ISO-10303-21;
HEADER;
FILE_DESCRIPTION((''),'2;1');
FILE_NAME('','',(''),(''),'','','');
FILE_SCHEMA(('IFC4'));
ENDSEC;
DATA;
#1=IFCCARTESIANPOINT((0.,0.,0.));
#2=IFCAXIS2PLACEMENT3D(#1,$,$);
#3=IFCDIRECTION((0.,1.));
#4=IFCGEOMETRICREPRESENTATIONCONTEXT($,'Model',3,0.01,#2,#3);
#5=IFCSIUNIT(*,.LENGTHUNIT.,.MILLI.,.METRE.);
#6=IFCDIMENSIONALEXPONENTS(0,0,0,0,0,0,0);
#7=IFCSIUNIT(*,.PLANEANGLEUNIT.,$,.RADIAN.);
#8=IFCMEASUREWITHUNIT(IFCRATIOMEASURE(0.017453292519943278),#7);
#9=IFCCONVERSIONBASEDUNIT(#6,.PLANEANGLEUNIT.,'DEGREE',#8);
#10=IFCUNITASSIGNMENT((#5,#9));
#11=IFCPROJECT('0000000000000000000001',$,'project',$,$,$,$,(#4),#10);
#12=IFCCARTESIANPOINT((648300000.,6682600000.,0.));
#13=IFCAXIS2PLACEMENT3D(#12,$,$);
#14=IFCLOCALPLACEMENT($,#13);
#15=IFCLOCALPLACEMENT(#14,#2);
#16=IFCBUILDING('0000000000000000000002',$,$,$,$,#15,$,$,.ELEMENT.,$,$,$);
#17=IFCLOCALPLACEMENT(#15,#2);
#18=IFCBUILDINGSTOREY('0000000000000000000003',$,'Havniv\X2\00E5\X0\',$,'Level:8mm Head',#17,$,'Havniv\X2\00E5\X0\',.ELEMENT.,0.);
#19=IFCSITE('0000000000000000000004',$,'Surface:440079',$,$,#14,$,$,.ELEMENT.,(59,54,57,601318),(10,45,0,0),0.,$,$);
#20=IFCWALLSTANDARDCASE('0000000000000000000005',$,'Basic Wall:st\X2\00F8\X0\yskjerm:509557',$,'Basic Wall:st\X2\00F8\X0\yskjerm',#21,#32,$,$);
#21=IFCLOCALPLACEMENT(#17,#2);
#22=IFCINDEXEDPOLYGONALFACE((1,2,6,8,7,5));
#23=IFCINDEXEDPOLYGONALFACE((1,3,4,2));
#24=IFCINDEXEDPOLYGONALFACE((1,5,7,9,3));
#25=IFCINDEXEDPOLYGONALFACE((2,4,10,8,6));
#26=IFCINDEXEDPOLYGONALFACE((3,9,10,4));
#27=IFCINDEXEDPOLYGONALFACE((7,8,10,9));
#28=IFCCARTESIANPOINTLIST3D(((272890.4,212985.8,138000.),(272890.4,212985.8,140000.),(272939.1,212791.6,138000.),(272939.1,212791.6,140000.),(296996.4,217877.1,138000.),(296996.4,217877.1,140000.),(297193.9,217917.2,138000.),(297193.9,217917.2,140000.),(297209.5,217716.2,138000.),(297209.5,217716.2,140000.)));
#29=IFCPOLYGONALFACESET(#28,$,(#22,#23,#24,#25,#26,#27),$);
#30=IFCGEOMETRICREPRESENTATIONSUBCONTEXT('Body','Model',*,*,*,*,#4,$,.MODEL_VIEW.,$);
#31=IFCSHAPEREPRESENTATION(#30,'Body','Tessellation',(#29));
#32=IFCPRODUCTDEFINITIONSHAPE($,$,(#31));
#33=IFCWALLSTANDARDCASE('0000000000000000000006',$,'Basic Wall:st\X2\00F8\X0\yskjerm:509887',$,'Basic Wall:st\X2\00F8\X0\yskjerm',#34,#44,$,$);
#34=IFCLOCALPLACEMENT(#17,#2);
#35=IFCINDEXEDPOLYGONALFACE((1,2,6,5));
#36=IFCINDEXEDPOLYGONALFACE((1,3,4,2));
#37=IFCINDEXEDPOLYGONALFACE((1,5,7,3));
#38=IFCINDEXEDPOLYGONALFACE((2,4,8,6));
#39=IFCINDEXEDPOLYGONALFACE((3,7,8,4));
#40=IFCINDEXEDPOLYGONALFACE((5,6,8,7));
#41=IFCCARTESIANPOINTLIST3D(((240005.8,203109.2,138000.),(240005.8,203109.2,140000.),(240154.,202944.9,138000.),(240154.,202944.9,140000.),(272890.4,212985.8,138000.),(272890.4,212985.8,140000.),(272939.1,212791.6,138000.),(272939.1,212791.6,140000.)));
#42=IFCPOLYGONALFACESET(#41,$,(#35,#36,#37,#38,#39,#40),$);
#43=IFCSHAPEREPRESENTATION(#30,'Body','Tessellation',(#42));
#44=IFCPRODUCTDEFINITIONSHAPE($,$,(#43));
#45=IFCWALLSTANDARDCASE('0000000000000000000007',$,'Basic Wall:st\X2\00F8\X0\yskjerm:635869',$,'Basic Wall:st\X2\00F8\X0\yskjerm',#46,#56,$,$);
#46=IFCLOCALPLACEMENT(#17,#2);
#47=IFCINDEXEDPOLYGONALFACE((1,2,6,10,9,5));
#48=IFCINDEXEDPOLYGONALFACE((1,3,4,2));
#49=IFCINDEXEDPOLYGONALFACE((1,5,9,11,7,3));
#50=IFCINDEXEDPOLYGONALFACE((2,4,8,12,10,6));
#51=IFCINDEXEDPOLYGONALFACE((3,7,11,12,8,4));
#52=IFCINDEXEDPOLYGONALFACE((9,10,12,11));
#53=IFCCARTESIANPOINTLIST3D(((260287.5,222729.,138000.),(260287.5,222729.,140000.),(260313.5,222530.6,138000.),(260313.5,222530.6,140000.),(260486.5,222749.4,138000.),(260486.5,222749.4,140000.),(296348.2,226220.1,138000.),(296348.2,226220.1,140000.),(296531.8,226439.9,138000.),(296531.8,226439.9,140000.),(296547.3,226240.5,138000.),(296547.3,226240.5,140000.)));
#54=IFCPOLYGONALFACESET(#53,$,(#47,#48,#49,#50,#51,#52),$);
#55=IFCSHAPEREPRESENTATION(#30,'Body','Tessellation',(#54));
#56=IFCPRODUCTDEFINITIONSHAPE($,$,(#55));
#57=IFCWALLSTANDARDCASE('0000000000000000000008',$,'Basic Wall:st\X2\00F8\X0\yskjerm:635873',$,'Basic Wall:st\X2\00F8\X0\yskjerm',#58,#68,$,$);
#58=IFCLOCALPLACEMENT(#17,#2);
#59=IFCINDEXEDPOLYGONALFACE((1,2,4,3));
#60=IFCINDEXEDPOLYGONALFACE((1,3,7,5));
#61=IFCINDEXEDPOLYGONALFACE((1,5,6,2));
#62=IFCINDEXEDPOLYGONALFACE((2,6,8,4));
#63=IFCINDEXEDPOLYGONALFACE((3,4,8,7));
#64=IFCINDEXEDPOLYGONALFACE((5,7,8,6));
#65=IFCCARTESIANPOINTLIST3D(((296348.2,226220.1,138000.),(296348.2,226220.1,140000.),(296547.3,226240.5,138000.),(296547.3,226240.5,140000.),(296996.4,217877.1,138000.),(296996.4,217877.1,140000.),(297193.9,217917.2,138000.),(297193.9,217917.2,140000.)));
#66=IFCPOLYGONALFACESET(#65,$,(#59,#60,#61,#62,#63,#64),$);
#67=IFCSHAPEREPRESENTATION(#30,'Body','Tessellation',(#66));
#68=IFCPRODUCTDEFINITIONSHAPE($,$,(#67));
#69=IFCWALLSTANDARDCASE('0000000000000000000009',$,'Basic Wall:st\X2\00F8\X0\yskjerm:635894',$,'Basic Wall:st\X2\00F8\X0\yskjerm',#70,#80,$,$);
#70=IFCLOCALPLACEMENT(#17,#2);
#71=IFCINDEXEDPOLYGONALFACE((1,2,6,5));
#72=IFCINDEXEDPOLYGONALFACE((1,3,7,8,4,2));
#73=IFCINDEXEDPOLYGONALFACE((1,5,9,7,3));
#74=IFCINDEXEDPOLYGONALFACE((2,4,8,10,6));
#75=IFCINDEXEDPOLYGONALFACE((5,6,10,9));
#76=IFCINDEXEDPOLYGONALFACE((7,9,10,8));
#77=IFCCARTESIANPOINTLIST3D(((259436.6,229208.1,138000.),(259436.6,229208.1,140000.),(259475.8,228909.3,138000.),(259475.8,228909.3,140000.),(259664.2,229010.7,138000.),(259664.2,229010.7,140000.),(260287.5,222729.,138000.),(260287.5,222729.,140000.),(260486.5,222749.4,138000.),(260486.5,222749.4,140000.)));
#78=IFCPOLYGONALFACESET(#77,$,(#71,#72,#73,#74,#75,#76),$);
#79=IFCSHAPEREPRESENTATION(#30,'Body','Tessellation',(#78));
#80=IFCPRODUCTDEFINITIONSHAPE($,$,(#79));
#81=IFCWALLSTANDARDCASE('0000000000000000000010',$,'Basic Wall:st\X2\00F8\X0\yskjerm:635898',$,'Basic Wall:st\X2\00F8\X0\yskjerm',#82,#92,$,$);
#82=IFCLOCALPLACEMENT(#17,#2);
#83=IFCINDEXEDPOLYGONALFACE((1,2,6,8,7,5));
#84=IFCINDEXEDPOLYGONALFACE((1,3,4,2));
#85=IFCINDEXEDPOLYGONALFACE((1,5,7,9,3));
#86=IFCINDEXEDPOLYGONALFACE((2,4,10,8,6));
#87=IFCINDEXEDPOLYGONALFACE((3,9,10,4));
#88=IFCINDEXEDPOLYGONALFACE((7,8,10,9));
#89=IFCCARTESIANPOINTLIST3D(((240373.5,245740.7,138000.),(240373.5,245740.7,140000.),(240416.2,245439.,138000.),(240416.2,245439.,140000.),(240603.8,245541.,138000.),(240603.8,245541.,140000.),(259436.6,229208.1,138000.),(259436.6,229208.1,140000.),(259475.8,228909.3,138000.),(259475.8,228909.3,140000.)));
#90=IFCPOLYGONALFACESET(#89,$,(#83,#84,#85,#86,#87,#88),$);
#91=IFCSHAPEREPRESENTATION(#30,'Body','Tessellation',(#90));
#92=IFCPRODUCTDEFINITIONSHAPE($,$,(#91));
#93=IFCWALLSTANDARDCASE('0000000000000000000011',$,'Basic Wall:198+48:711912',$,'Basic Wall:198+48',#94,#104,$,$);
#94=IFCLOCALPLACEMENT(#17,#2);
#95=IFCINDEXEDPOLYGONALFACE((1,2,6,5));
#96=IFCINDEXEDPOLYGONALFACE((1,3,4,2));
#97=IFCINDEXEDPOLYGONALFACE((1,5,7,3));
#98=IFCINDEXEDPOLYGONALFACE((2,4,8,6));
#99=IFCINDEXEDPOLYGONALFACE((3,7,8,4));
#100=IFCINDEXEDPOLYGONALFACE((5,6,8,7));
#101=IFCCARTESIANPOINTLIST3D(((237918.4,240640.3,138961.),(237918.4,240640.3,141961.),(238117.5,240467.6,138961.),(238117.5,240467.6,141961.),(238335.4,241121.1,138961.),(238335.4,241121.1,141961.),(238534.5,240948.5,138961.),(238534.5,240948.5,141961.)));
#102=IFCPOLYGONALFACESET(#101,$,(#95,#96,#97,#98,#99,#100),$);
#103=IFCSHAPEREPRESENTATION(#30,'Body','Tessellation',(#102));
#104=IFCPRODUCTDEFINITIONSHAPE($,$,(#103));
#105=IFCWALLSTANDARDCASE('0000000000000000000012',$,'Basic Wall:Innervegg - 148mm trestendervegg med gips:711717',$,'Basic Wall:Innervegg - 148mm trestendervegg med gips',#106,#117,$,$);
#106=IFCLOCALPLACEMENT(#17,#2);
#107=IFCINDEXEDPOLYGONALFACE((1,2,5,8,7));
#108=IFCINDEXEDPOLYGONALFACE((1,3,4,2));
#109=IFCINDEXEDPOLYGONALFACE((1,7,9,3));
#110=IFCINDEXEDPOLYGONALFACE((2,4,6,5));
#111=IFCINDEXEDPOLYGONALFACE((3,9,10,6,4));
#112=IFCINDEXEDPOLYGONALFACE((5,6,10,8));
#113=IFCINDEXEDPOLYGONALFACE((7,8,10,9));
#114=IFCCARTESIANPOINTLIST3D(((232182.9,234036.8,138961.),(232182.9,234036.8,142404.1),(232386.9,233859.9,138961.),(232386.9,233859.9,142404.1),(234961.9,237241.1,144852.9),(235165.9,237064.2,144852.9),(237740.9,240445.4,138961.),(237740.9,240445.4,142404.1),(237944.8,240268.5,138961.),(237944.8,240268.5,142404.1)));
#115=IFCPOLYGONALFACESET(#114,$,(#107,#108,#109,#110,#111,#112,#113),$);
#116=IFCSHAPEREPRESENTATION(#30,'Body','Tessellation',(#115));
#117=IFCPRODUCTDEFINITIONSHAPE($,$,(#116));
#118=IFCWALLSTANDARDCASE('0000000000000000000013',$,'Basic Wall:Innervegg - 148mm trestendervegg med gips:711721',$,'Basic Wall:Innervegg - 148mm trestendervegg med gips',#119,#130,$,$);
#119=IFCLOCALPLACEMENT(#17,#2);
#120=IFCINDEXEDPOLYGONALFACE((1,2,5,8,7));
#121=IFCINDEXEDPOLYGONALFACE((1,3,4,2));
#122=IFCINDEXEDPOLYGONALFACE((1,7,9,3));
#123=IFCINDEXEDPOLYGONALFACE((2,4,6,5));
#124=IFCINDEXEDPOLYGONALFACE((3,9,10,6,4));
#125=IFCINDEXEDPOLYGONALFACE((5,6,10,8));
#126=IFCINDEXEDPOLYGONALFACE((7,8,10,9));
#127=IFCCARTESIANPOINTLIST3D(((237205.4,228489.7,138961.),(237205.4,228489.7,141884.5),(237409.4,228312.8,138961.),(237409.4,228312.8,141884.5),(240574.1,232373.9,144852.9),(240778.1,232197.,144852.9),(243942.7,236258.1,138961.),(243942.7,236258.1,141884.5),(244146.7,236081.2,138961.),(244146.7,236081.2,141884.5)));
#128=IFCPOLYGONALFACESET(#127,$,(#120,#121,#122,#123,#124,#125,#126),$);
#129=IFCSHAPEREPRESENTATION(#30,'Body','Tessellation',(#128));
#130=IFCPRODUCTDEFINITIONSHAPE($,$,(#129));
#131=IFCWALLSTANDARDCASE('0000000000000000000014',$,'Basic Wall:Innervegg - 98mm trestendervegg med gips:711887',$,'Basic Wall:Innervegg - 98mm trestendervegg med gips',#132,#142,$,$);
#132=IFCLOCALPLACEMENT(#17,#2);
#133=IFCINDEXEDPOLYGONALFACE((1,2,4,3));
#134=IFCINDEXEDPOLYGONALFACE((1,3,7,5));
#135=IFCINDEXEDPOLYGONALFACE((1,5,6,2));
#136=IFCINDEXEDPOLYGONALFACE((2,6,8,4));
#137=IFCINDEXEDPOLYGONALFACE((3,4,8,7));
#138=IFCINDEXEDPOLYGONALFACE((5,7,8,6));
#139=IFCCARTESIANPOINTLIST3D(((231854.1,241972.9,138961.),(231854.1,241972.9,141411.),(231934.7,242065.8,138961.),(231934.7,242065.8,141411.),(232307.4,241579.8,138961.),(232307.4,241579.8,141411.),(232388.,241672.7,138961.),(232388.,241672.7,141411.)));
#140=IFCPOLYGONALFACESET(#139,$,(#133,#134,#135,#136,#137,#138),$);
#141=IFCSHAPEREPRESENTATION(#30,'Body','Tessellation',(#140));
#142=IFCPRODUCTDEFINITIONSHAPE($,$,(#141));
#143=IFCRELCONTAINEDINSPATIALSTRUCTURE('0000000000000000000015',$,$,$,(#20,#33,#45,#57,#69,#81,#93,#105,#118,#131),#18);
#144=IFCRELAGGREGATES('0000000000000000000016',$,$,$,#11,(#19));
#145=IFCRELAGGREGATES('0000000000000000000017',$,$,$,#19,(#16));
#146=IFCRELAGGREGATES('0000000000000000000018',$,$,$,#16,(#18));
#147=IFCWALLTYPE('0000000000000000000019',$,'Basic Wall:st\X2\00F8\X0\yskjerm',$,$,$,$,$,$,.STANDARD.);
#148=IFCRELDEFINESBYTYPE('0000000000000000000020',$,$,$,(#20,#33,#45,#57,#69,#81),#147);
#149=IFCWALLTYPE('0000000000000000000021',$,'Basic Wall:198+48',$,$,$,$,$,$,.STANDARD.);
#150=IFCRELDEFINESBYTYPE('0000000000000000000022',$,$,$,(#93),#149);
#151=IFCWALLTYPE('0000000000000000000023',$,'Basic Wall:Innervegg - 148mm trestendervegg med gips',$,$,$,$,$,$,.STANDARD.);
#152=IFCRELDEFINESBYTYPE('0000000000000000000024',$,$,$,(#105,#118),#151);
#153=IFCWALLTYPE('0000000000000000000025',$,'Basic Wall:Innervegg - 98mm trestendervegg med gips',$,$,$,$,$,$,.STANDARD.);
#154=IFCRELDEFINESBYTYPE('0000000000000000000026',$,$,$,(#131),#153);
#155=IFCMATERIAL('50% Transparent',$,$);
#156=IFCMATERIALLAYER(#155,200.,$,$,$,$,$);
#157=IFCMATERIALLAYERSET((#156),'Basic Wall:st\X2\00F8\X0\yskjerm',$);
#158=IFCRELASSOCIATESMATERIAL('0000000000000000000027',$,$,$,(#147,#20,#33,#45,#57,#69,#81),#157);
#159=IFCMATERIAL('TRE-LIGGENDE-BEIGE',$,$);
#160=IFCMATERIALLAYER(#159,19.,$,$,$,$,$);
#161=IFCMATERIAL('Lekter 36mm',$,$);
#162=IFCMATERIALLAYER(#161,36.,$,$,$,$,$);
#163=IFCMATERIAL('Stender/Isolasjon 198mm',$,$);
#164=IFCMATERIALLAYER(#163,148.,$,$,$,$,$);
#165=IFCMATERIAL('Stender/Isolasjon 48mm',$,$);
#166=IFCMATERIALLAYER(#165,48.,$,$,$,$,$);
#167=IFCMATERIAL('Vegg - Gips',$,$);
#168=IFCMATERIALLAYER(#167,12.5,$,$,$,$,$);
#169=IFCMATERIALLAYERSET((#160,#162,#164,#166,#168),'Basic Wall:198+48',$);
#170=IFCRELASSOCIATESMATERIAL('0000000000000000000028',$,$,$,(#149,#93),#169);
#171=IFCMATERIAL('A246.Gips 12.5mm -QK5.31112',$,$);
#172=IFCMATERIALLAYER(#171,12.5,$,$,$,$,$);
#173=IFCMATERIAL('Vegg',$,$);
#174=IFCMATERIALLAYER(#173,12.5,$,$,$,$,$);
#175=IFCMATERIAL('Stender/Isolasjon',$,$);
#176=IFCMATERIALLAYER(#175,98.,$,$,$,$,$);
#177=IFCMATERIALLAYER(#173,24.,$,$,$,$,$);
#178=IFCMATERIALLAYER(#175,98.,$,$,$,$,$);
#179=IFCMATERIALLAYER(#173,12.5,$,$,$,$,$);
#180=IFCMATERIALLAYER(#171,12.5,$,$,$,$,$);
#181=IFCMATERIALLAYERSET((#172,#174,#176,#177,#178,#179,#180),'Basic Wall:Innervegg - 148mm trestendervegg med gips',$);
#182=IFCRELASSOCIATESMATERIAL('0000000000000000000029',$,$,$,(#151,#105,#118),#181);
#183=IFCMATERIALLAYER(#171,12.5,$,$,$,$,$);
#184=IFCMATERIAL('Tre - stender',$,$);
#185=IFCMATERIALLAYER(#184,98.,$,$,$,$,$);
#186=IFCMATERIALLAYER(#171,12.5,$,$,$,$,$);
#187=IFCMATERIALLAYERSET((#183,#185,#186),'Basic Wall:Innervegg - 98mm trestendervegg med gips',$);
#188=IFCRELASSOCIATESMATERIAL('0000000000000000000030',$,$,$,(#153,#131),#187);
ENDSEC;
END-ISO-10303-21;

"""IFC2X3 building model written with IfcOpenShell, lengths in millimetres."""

from ifc_helpers import new_model, entity, si_unit, converted_unit, direction, frame, frame_2d, origin, place, context, subcontext, project, spatial, polyline, rectangle, outline, extrude, clip, bounded_halfspace, material, layer, layer_set, layer_usage, type_object, element, save


model = new_model("IFC2X3")

# Units and contexts
model_context = context("Model", 3, precision=0.01, world=origin(), true_north=direction((0.0, 1.0)))
body_context = subcontext(model_context, "Body", "Model", "MODEL_VIEW")
ifc_project = project(units=[si_unit("LENGTHUNIT", "METRE", prefix="MILLI"), converted_unit("PLANEANGLEUNIT", "DEGREE", entity("IfcRatioMeasure", 0.017453292519943278), si_unit("PLANEANGLEUNIT", "RADIAN"), dimensions=[0, 0, 0, 0, 0, 0, 0])], contexts=[model_context])

# Site, building, storey
site_placement = place(None, frame((648300000.0, 6682600000.0, 0.0)))
site = spatial("IfcSite", under=ifc_project, at=site_placement, Name="Surface:440079", CompositionType="ELEMENT", RefLatitude=(59, 54, 57, 601318), RefLongitude=(10, 45, 0, 0), RefElevation=0.0)
building_placement = place(site_placement, origin())
building = spatial("IfcBuilding", under=site, at=building_placement, CompositionType="ELEMENT")
storey_placement = place(building_placement, origin())
storey = spatial("IfcBuildingStorey", under=building, at=storey_placement, Name="Havnivå", ObjectType="Level:8mm Head", LongName="Havnivå", CompositionType="ELEMENT", Elevation=0.0)

# Walls
ifc_material_1 = material(Name="50% Transparent")
ifc_layer_1 = layer(ifc_material_1, 200.0)
ifc_layer_set_1 = layer_set([ifc_layer_1], Name="Basic Wall:støyskjerm")
ifc_layer_usage_1 = layer_usage(ifc_layer_set_1, "AXIS2", "NEGATIVE", 100.0)
wall_type_1 = type_object("IfcWallType", Name="Basic Wall:støyskjerm", PredefinedType="STANDARD", material=ifc_layer_set_1)
wall_1_placement = place(storey_placement, frame((297213.8, 217819.1, 138000.0), z_axis=(0.0, 0.0, 1.0), x_axis=(-0.980029, -0.198854, 0.0)))
element("IfcWallStandardCase", 1, at=wall_1_placement, inside=storey, type_object=wall_type_1, material=ifc_layer_usage_1, Name="Basic Wall:støyskjerm:509557", ObjectType="Basic Wall:støyskjerm", context=body_context, shape_type="SweptSolid", body=[
    extrude(outline(polyline([(24798.8, -100.0), (24789.6, 100.0), (24.7, 100.0), (0.0, -100.0), (201.5, -100.0), (24798.8, -100.0)])), origin(), (0.0, 0.0, 1.0), 2000.0),
])
ifc_layer_usage_2 = layer_usage(ifc_layer_set_1, "AXIS2", "NEGATIVE", 100.0)
wall_2_placement = place(storey_placement, frame((272919.1, 212890.0, 138000.0), z_axis=(0.0, 0.0, 1.0), x_axis=(-0.957736, -0.287648, 0.0)))
element("IfcWallStandardCase", 2, at=wall_2_placement, inside=storey, type_object=wall_type_1, material=ifc_layer_usage_2, Name="Basic Wall:støyskjerm:509887", ObjectType="Basic Wall:støyskjerm", context=body_context, shape_type="SweptSolid", body=[
    extrude(outline(polyline([(34335.7, -100.0), (34241.0, 100.0), (9.2, 100.0), (0.0, -100.0), (34335.7, -100.0)])), origin(), (0.0, 0.0, 1.0), 2000.0),
])
ifc_layer_usage_3 = layer_usage(ifc_layer_set_1, "AXIS2", "NEGATIVE", 100.0)
wall_3_placement = place(storey_placement, frame((260297.6, 222629.5, 138000.0), z_axis=(0.0, 0.0, 1.0), x_axis=(0.994799, 0.101854, 0.0)))
element("IfcWallStandardCase", 3, at=wall_3_placement, inside=storey, type_object=wall_type_1, material=ifc_layer_usage_3, Name="Basic Wall:støyskjerm:635869", ObjectType="Basic Wall:støyskjerm", context=body_context, shape_type="SweptSolid", body=[
    extrude(outline(polyline([(36428.9, -100.0), (36433.8, 100.0), (200.1, 100.0), (0.0, 100.0), (5.7, -100.0), (36228.8, -100.0), (36428.9, -100.0)])), origin(), (0.0, 0.0, 1.0), 2000.0),
])
ifc_layer_usage_4 = layer_usage(ifc_layer_set_1, "AXIS2", "NEGATIVE", 100.0)
wall_4_placement = place(storey_placement, frame((297096.1, 217884.8, 138000.0), z_axis=(0.0, 0.0, 1.0), x_axis=(-0.077456, 0.996996, 0.0)))
element("IfcWallStandardCase", 4, at=wall_4_placement, inside=storey, type_object=wall_type_1, material=ifc_layer_usage_4, Name="Basic Wall:støyskjerm:635873", ObjectType="Basic Wall:støyskjerm", context=body_context, shape_type="SweptSolid", body=[
    extrude(outline(polyline([(8373.0, -100.0), (8368.1, 100.0), (0.0, 100.0), (24.7, -100.0), (8373.0, -100.0)])), origin(), (0.0, 0.0, 1.0), 2000.0),
])
ifc_layer_usage_5 = layer_usage(ifc_layer_set_1, "AXIS2", "NEGATIVE", 100.0)
wall_5_placement = place(storey_placement, frame((259535.7, 229221.1, 138000.0), z_axis=(0.0, 0.0, 1.0), x_axis=(0.130211, -0.991486, 0.0)))
element("IfcWallStandardCase", 5, at=wall_5_placement, inside=storey, type_object=wall_type_1, material=ifc_layer_usage_5, Name="Basic Wall:støyskjerm:635894", ObjectType="Basic Wall:støyskjerm", context=body_context, shape_type="SweptSolid", body=[
    extrude(outline(polyline([(6534.7, -100.0), (6540.4, 100.0), (225.4, 100.0), (0.0, -100.0), (301.3, -100.0), (6534.7, -100.0)])), origin(), (0.0, 0.0, 1.0), 2000.0),
])
ifc_layer_usage_6 = layer_usage(ifc_layer_set_1, "AXIS2", "NEGATIVE", 100.0)
wall_6_placement = place(storey_placement, frame((259541.3, 228984.9, 138000.0), z_axis=(0.0, 0.0, 1.0), x_axis=(-0.755467, 0.655187, 0.0)))
element("IfcWallStandardCase", 6, at=wall_6_placement, inside=storey, type_object=wall_type_1, material=ifc_layer_usage_6, Name="Basic Wall:støyskjerm:635898", ObjectType="Basic Wall:støyskjerm", context=body_context, shape_type="SweptSolid", body=[
    extrude(outline(polyline([(25458.8, -100.0), (25228.9, 100.0), (0.0, 100.0), (225.4, -100.0), (25154.1, -100.0), (25458.8, -100.0)])), origin(), (0.0, 0.0, 1.0), 2000.0),
])
ifc_material_2 = material(Name="TRE-LIGGENDE-BEIGE")
ifc_layer_2 = layer(ifc_material_2, 19.0)
ifc_material_3 = material(Name="Lekter 36mm")
ifc_layer_3 = layer(ifc_material_3, 36.0)
ifc_material_4 = material(Name="Stender/Isolasjon 198mm")
ifc_layer_4 = layer(ifc_material_4, 148.0)
ifc_material_5 = material(Name="Stender/Isolasjon 48mm")
ifc_layer_5 = layer(ifc_material_5, 48.0)
ifc_material_6 = material(Name="Vegg - Gips")
ifc_layer_6 = layer(ifc_material_6, 12.5)
ifc_layer_set_2 = layer_set([ifc_layer_2, ifc_layer_3, ifc_layer_4, ifc_layer_5, ifc_layer_6], Name="Basic Wall:198+48")
ifc_layer_usage_7 = layer_usage(ifc_layer_set_2, "AXIS2", "NEGATIVE", 131.8)
wall_type_2 = type_object("IfcWallType", Name="Basic Wall:198+48", PredefinedType="STANDARD", material=ifc_layer_set_2)
wall_7_placement = place(storey_placement, frame((238017.9, 240553.9, 138961.0), z_axis=(0.0, 0.0, 1.0), x_axis=(0.655187, 0.755467, 0.0)))
element("IfcWallStandardCase", 7, at=wall_7_placement, inside=storey, type_object=wall_type_2, material=ifc_layer_usage_7, Name="Basic Wall:198+48:711912", ObjectType="Basic Wall:198+48", context=body_context, shape_type="SweptSolid", body=[
    extrude(rectangle(XDim=636.5, YDim=263.5, at=frame_2d((318.2, 0.0), x_axis=(-1.0, 0.0))), origin(), (0.0, 0.0, 1.0), 3000.0),
])
ifc_material_7 = material(Name="A246.Gips 12.5mm -QK5.31112")
ifc_layer_7 = layer(ifc_material_7, 12.5)
ifc_material_8 = material(Name="Vegg")
ifc_layer_8 = layer(ifc_material_8, 12.5)
ifc_material_9 = material(Name="Stender/Isolasjon")
ifc_layer_9 = layer(ifc_material_9, 98.0)
ifc_layer_10 = layer(ifc_material_8, 24.0)
ifc_layer_11 = layer(ifc_material_9, 98.0)
ifc_layer_12 = layer(ifc_material_8, 12.5)
ifc_layer_13 = layer(ifc_material_7, 12.5)
ifc_layer_set_3 = layer_set([ifc_layer_7, ifc_layer_8, ifc_layer_9, ifc_layer_10, ifc_layer_11, ifc_layer_12, ifc_layer_13], Name="Basic Wall:Innervegg - 148mm trestendervegg med gips")
ifc_layer_usage_8 = layer_usage(ifc_layer_set_3, "AXIS2", "NEGATIVE", 135.0)
wall_type_3 = type_object("IfcWallType", Name="Basic Wall:Innervegg - 148mm trestendervegg med gips", PredefinedType="STANDARD", material=ifc_layer_set_3)
wall_8_placement = place(storey_placement, frame((232284.9, 233948.4, 138961.0), z_axis=(0.0, 0.0, 1.0), x_axis=(0.655187, 0.755467, 0.0)))
element("IfcWallStandardCase", 8, at=wall_8_placement, inside=storey, type_object=wall_type_3, material=ifc_layer_usage_8, Name="Basic Wall:Innervegg - 148mm trestendervegg med gips:711717", ObjectType="Basic Wall:Innervegg - 148mm trestendervegg med gips", context=body_context, shape_type="Clipping", body=[
    clip(clip(extrude(rectangle(XDim=8483.0, YDim=270.0, at=frame_2d((4241.5, 0.0), x_axis=(-1.0, 0.0))), origin(), (0.0, 0.0, 1.0), 5891.9), bounded_halfspace(frame((0.0, -135.0, 3443.1), z_axis=(-0.5, 0.0, 0.866025), x_axis=(0.0, -1.0, 0.0)), False, frame((0.0, -135.0, 3443.1)), polyline([(0.0, 0.0), (1292809.2, 0.0), (1292809.2, 82296.0), (0.0, 82296.0), (0.0, 0.0)]))), bounded_halfspace(frame((4241.5, -135.0, 5891.9), z_axis=(0.5, 0.0, 0.866025), x_axis=(0.0, 1.0, 0.0)), False, frame((4241.5, -135.0, 5891.9)), polyline([(0.0, 0.0), (1292809.2, 0.0), (1292809.2, 82296.0), (0.0, 82296.0), (0.0, 0.0)]))),
])
ifc_layer_usage_9 = layer_usage(ifc_layer_set_3, "AXIS2", "NEGATIVE", 135.0)
wall_9_placement = place(storey_placement, frame((237307.4, 228401.2, 138961.0), z_axis=(0.0, 0.0, 1.0), x_axis=(0.655187, 0.755467, 0.0)))
element("IfcWallStandardCase", 9, at=wall_9_placement, inside=storey, type_object=wall_type_3, material=ifc_layer_usage_9, Name="Basic Wall:Innervegg - 148mm trestendervegg med gips:711721", ObjectType="Basic Wall:Innervegg - 148mm trestendervegg med gips", context=body_context, shape_type="Clipping", body=[
    clip(clip(extrude(rectangle(XDim=10283.0, YDim=270.0, at=frame_2d((5141.5, 0.0), x_axis=(-1.0, 0.0))), origin(), (0.0, 0.0, 1.0), 5891.9), bounded_halfspace(frame((0.0, 135.0, 2923.5), z_axis=(-0.5, 0.0, 0.866025), x_axis=(0.0, -1.0, 0.0)), False, frame((0.0, 135.0, 2923.5)), polyline([(0.0, 0.0), (0.0, -82296.0), (1567129.2, -82296.0), (1567129.2, 0.0), (0.0, 0.0)]))), bounded_halfspace(frame((10283.0, -135.0, 2923.5), z_axis=(0.5, 0.0, 0.866025), x_axis=(0.0, 1.0, 0.0)), False, frame((10283.0, -135.0, 2923.5)), polyline([(0.0, 0.0), (0.0, 82296.0), (-1567129.2, 82296.0), (-1567129.2, 0.0), (0.0, 0.0)]))),
])
ifc_layer_14 = layer(ifc_material_7, 12.5)
ifc_material_10 = material(Name="Tre - stender")
ifc_layer_15 = layer(ifc_material_10, 98.0)
ifc_layer_16 = layer(ifc_material_7, 12.5)
ifc_layer_set_4 = layer_set([ifc_layer_14, ifc_layer_15, ifc_layer_16], Name="Basic Wall:Innervegg - 98mm trestendervegg med gips")
ifc_layer_usage_10 = layer_usage(ifc_layer_set_4, "AXIS2", "NEGATIVE", 61.5)
wall_type_4 = type_object("IfcWallType", Name="Basic Wall:Innervegg - 98mm trestendervegg med gips", PredefinedType="STANDARD", material=ifc_layer_set_4)
wall_10_placement = place(storey_placement, frame((232347.7, 241626.2, 138961.0), z_axis=(0.0, 0.0, 1.0), x_axis=(-0.755467, 0.655187, 0.0)))
element("IfcWallStandardCase", 10, at=wall_10_placement, inside=storey, type_object=wall_type_4, material=ifc_layer_usage_10, Name="Basic Wall:Innervegg - 98mm trestendervegg med gips:711887", ObjectType="Basic Wall:Innervegg - 98mm trestendervegg med gips", context=body_context, shape_type="SweptSolid", body=[
    extrude(rectangle(XDim=600.0, YDim=123.0, at=frame_2d((300.0, 0.0), x_axis=(-1.0, 0.0))), origin(), (0.0, 0.0, 1.0), 2450.0),
])

save(model, "model.ifc")
